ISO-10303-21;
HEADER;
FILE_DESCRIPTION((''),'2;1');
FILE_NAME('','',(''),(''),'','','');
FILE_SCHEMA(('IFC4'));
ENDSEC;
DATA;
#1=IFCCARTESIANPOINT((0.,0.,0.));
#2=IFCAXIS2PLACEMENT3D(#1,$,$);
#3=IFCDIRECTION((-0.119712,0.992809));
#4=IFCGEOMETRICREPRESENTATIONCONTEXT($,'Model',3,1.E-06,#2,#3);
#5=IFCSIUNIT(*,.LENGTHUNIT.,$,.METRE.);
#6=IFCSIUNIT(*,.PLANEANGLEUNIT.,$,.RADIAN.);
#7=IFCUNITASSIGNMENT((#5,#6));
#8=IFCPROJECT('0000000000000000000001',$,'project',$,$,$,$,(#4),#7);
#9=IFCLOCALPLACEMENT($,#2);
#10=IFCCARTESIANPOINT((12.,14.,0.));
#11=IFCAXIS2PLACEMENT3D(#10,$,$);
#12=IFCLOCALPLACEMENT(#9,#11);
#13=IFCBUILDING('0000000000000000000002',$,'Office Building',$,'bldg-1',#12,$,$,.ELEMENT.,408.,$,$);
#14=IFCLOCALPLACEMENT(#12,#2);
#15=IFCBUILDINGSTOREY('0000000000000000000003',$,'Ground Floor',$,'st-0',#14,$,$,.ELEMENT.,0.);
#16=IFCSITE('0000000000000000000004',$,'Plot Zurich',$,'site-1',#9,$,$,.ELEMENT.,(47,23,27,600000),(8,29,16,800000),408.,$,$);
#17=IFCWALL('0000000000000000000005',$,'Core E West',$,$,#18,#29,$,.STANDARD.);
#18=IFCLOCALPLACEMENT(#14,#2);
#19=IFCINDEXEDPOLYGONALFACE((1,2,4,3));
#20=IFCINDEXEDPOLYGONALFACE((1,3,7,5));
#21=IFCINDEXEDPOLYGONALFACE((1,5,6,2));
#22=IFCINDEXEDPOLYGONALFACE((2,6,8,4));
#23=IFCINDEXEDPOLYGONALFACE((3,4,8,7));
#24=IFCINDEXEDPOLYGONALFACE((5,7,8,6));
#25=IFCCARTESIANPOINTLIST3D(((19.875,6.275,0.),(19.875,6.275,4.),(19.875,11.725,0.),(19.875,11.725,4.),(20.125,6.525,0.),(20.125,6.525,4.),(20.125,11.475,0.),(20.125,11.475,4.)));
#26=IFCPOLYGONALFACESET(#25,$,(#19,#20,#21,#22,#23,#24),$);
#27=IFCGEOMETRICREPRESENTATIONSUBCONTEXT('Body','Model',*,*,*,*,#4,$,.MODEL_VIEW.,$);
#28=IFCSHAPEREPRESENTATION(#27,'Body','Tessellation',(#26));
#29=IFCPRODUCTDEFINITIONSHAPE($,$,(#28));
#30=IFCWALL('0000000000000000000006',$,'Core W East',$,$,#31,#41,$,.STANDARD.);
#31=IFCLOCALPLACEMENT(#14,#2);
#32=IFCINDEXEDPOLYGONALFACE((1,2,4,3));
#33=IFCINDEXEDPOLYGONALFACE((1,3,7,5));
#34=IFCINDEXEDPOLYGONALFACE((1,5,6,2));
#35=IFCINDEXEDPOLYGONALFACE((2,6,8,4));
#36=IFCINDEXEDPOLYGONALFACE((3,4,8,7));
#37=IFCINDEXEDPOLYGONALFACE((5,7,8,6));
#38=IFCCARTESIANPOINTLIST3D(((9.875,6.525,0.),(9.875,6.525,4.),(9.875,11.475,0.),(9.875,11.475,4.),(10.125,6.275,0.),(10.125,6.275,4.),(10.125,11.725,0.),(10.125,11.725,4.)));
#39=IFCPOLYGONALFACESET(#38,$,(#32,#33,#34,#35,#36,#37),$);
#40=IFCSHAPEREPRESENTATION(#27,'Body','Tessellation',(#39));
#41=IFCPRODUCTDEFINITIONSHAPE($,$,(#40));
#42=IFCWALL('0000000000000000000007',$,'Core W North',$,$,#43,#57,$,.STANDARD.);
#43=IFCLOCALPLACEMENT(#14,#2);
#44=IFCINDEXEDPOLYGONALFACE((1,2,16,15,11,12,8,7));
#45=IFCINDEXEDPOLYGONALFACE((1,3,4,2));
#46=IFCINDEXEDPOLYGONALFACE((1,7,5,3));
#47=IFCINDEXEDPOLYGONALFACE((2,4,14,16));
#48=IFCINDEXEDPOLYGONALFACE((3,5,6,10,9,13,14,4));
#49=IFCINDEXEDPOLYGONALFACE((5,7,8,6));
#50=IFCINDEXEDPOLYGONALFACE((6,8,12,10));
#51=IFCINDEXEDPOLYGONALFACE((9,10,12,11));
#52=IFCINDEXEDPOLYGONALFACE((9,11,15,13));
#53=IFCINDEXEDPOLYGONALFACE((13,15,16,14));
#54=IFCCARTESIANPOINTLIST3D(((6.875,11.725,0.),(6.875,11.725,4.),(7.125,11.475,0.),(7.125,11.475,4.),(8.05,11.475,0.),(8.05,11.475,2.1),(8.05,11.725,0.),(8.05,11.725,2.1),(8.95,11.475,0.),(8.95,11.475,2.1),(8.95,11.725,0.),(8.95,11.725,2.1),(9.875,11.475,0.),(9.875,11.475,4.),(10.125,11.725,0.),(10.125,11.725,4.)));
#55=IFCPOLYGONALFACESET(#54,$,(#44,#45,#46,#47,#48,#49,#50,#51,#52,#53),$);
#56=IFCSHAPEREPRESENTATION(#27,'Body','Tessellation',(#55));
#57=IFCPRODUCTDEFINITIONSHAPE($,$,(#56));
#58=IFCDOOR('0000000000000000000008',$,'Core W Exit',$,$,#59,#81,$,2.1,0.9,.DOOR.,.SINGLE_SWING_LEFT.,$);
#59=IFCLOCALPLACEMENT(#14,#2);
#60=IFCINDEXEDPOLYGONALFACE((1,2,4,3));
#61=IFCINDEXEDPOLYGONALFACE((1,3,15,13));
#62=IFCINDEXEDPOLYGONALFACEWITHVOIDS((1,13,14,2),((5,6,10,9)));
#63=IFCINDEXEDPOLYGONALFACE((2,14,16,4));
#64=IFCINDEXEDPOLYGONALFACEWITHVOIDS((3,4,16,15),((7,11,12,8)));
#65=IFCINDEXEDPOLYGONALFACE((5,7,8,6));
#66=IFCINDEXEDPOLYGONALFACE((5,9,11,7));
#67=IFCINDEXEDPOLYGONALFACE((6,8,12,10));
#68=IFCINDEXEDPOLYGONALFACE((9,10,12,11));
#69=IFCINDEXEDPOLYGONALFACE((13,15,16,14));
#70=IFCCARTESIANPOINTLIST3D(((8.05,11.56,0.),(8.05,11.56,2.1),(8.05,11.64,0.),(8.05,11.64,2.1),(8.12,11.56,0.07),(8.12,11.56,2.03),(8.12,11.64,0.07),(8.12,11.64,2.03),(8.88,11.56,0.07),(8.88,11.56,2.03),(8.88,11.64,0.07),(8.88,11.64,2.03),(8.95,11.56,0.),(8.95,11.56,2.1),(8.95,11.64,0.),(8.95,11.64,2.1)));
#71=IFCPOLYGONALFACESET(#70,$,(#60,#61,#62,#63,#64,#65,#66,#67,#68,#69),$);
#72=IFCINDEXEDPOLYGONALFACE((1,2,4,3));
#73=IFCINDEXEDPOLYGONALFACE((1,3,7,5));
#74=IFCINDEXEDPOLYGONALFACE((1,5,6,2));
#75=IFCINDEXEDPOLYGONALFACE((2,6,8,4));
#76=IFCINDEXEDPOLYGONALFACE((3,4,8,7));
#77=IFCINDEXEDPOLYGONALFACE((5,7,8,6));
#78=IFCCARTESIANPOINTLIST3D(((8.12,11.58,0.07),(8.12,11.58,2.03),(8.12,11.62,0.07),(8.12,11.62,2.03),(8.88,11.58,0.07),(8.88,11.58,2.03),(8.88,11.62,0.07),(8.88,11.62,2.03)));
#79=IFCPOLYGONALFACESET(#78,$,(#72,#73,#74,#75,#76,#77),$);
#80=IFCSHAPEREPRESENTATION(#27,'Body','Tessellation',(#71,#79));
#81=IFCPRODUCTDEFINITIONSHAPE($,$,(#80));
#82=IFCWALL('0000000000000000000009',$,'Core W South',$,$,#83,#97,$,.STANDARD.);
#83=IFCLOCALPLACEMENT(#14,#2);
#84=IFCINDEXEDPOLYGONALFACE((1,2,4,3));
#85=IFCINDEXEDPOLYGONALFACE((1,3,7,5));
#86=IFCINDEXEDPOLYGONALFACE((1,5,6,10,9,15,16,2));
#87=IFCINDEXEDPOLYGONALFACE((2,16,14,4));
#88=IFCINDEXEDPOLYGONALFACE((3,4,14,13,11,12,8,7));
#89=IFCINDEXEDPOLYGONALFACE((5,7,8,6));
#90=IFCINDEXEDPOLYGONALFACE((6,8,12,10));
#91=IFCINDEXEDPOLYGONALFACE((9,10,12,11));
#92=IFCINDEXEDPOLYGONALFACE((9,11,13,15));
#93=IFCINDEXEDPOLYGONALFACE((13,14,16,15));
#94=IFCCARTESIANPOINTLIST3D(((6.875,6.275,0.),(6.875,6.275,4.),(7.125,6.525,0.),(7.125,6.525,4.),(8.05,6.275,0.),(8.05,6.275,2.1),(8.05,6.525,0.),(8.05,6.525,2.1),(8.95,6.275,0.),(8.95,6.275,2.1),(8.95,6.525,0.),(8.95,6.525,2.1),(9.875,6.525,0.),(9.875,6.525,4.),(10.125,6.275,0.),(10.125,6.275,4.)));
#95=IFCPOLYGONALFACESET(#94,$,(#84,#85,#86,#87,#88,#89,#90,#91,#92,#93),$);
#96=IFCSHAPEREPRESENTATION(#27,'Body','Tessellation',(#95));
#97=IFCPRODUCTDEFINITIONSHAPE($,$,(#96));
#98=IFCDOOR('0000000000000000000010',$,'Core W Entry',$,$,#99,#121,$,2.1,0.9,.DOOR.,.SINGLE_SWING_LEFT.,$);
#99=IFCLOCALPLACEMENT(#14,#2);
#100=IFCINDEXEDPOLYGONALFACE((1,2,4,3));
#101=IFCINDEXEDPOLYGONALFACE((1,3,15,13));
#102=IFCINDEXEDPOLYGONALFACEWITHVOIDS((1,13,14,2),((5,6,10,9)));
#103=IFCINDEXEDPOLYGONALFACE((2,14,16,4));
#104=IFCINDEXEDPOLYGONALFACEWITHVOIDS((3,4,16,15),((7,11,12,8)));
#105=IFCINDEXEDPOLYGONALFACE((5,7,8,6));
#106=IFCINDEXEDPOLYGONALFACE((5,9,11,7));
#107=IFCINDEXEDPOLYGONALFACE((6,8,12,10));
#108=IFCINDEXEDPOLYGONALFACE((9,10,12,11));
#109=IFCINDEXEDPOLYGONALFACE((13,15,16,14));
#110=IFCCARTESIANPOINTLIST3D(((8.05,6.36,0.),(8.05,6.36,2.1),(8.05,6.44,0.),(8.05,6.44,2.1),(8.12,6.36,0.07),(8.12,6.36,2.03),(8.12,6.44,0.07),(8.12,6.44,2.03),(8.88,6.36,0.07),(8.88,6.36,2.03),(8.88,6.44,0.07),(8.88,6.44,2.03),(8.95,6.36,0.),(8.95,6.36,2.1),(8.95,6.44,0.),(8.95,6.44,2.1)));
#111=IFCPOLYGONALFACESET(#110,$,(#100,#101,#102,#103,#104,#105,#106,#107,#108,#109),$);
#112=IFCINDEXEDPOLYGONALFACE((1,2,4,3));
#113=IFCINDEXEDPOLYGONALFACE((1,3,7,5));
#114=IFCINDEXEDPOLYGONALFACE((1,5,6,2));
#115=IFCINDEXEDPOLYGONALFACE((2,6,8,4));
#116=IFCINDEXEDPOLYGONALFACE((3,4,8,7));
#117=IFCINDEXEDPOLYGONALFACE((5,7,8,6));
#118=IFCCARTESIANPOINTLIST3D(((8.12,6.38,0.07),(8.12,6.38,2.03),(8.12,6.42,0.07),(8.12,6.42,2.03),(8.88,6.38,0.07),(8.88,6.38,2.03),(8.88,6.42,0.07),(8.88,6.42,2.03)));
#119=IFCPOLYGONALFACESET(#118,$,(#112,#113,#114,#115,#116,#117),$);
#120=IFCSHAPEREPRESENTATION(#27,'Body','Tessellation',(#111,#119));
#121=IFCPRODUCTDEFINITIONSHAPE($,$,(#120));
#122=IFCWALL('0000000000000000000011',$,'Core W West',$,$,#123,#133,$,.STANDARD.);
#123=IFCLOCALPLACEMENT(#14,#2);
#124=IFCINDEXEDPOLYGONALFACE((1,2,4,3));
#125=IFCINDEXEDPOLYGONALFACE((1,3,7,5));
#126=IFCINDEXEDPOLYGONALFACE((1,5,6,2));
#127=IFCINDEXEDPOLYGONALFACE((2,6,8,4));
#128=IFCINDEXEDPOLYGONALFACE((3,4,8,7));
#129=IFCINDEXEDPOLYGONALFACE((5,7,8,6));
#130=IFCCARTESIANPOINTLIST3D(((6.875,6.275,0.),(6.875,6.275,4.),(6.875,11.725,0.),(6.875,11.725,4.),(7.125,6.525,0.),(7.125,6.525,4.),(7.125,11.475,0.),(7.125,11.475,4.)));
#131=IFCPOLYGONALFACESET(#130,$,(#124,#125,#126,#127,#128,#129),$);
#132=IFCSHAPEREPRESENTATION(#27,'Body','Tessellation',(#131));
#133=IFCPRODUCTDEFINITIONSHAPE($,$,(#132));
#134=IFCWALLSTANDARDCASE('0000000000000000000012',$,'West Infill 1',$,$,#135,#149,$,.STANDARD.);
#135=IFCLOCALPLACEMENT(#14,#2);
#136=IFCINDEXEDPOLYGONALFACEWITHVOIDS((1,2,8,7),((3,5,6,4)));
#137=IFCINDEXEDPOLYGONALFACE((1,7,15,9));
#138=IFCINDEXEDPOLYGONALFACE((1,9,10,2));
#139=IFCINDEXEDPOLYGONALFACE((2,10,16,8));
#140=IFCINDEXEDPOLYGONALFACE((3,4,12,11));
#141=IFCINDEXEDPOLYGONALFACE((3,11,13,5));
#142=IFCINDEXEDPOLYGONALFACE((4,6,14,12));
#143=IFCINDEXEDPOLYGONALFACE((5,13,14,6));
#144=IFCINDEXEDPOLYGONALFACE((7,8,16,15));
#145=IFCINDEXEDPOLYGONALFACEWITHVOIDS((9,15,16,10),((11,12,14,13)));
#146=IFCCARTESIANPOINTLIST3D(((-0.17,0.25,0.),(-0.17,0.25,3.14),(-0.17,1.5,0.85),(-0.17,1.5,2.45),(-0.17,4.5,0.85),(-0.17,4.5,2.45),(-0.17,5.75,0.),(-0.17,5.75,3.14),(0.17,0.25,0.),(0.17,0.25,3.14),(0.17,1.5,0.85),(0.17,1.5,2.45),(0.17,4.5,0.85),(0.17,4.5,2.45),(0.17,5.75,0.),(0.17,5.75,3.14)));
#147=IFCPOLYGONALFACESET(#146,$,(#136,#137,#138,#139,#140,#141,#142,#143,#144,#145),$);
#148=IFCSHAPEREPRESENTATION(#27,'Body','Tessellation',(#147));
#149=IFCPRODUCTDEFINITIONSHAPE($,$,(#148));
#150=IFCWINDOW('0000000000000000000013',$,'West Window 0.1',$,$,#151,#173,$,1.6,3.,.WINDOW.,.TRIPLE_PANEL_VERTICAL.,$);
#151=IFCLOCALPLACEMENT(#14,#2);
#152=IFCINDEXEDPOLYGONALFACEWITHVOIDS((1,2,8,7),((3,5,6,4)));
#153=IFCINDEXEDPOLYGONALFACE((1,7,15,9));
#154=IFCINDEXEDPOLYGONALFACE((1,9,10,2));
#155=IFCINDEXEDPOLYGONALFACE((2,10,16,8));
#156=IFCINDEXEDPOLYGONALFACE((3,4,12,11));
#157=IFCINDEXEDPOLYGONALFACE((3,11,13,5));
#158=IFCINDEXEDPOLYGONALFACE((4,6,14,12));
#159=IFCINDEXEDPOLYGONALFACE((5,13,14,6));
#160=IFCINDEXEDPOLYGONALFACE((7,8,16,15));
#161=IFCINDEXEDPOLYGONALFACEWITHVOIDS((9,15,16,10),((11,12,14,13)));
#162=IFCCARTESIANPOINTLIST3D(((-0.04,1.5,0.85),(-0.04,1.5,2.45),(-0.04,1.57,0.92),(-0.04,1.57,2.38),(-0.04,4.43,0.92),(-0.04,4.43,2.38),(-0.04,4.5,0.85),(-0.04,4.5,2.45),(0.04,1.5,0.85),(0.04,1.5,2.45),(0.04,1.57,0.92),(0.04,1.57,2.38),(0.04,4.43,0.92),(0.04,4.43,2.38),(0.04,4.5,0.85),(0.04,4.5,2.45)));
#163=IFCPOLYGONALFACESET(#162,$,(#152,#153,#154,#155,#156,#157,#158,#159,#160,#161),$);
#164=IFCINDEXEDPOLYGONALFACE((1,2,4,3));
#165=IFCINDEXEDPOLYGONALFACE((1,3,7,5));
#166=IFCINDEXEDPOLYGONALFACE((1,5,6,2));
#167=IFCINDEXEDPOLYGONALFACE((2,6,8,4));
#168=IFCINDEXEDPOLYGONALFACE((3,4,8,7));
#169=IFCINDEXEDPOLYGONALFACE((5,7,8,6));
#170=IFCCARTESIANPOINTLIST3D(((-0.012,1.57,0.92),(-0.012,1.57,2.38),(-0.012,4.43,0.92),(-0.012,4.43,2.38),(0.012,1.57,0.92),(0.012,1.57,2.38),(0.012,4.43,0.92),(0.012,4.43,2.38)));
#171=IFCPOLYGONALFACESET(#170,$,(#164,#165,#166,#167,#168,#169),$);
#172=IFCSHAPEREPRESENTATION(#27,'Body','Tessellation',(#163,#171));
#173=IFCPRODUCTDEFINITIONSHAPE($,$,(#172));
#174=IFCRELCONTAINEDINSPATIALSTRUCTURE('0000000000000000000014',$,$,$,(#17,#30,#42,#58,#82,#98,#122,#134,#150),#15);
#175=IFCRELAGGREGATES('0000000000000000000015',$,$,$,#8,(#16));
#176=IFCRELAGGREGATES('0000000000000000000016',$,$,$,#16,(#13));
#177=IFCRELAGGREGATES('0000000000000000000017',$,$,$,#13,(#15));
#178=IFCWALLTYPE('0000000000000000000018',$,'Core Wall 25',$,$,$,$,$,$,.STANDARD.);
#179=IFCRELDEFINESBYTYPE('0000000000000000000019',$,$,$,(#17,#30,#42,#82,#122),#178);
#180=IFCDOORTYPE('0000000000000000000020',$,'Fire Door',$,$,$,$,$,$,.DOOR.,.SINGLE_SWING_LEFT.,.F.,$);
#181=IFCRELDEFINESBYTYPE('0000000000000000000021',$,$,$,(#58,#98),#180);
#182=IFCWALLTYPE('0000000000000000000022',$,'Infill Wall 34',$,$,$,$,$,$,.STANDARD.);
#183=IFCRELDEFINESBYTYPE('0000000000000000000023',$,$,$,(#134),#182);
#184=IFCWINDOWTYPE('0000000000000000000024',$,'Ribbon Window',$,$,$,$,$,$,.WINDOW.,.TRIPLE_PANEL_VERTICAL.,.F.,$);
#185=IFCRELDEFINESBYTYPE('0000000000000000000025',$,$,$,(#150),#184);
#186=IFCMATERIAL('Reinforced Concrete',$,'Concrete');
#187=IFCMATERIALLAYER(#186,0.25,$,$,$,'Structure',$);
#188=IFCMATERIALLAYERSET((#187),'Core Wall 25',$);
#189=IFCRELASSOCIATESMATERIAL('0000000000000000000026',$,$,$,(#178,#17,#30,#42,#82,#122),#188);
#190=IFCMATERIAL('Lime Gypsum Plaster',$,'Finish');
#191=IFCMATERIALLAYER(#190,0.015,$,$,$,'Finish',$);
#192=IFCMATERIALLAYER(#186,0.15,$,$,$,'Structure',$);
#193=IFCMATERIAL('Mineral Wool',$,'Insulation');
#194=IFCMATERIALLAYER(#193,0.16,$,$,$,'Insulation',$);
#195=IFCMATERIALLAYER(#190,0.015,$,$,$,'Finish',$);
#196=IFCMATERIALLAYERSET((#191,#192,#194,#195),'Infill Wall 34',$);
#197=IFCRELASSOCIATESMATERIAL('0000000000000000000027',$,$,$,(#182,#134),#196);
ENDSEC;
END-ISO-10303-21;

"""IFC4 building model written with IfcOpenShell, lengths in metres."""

from ifc_helpers import new_model, si_unit, direction, frame, frame_2d, origin, origin_2d, place, context, subcontext, project, spatial, polyline, rectangle, outline, extrude, material, layer, layer_set, layer_usage, type_object, element, fill, save


model = new_model("IFC4")

# Units and contexts
model_context = context("Model", 3, precision=1e-06, world=origin(), true_north=direction((-0.119712, 0.992809)))
body_context = subcontext(model_context, "Body", "Model", "MODEL_VIEW")
ifc_project = project(units=[si_unit("LENGTHUNIT", "METRE"), si_unit("PLANEANGLEUNIT", "RADIAN")], contexts=[model_context])

# Site, building, storey
site_placement = place(None, origin())
site = spatial("IfcSite", under=ifc_project, at=site_placement, Name="Plot Zurich", ObjectType="site-1", CompositionType="ELEMENT", RefLatitude=(47, 23, 27, 600000), RefLongitude=(8, 29, 16, 800000), RefElevation=408.0)
building_placement = place(site_placement, frame((12.0, 14.0, 0.0)))
building = spatial("IfcBuilding", under=site, at=building_placement, Name="Office Building", ObjectType="bldg-1", CompositionType="ELEMENT", ElevationOfRefHeight=408.0)
storey_placement = place(building_placement, origin())
storey = spatial("IfcBuildingStorey", under=building, at=storey_placement, Name="Ground Floor", ObjectType="st-0", CompositionType="ELEMENT", Elevation=0.0)

# Shared definitions
ifc_material_1 = material(Name="Reinforced Concrete", Category="Concrete")

# Shared definitions
ifc_material_2 = material(Name="Mineral Wool", Category="Insulation")

# Shared definitions
ifc_layer_1 = layer(ifc_material_1, 0.25, Category="Structure")
ifc_layer_set_1 = layer_set([ifc_layer_1], Name="Core Wall 25")
wall_type_1 = type_object("IfcWallType", Name="Core Wall 25", PredefinedType="STANDARD", material=ifc_layer_set_1)

# Shared definitions
door_type = type_object("IfcDoorType", Name="Fire Door", OperationType="SINGLE_SWING_LEFT", ParameterTakesPrecedence=False, PredefinedType="DOOR")

# Walls
ifc_layer_usage_1 = layer_usage(ifc_layer_set_1, "AXIS2", "NEGATIVE", 0.125)
wall_1_placement = place(storey_placement, origin())
element("IfcWall", 1, at=wall_1_placement, inside=storey, type_object=wall_type_1, material=ifc_layer_usage_1, Name="Core E West", PredefinedType="STANDARD", context=body_context, shape_type="SweptSolid", body=[
    extrude(outline(polyline([(19.875, 11.725), (19.875, 6.275), (20.125, 6.525), (20.125, 11.475), (19.875, 11.725)])), origin(), (0.0, 0.0, 1.0), 4.0),
])
ifc_layer_usage_2 = layer_usage(ifc_layer_set_1, "AXIS2", "NEGATIVE", 0.125)
wall_2_placement = place(storey_placement, origin())
element("IfcWall", 2, at=wall_2_placement, inside=storey, type_object=wall_type_1, material=ifc_layer_usage_2, Name="Core W East", PredefinedType="STANDARD", context=body_context, shape_type="SweptSolid", body=[
    extrude(outline(polyline([(10.125, 6.275), (10.125, 11.725), (9.875, 11.475), (9.875, 6.525), (10.125, 6.275)])), origin(), (0.0, 0.0, 1.0), 4.0),
])

# Walls, openings, doors
ifc_layer_usage_3 = layer_usage(ifc_layer_set_1, "AXIS2", "NEGATIVE", 0.125)
wall_3_placement = place(storey_placement, origin())
wall_3 = element("IfcWall", 3, at=wall_3_placement, inside=storey, type_object=wall_type_1, material=ifc_layer_usage_3, Name="Core W North", PredefinedType="STANDARD", context=body_context, shape_type="SweptSolid", body=[
    extrude(outline(polyline([(10.125, 11.725), (6.875, 11.725), (7.125, 11.475), (9.875, 11.475), (10.125, 11.725)])), origin(), (0.0, 0.0, 1.0), 4.0),
])
opening_1_placement = place(wall_3_placement, frame((8.5, 11.6, 0.0), z_axis=(0.0, 0.0, 1.0), x_axis=(-1.0, 0.0, 0.0)))
opening_1 = element("IfcOpeningElement", 4, at=opening_1_placement, cuts=wall_3, PredefinedType="OPENING", context=body_context, shape_type="SweptSolid", body=[
    extrude(rectangle(XDim=0.9, YDim=0.25, at=origin_2d()), origin(), (0.0, 0.0, 1.0), 2.1),
])
door_1_placement = place(opening_1_placement, frame((0.0, 0.0, 0.0), z_axis=(0.0, -1.0, 0.0), x_axis=(1.0, 0.0, 0.0)))
door_1 = element("IfcDoor", 5, at=door_1_placement, inside=storey, type_object=door_type, Name="Core W Exit", OperationType="SINGLE_SWING_LEFT", OverallHeight=2.1, OverallWidth=0.9, PredefinedType="DOOR", context=body_context, shape_type="SweptSolid", body=[
    extrude(outline(polyline([(-0.45, 0.0), (0.45, 0.0), (0.45, 2.1), (-0.45, 2.1), (-0.45, 0.0)]), holes=[polyline([(-0.38, 0.07), (0.38, 0.07), (0.38, 2.03), (-0.38, 2.03), (-0.38, 0.07)])]), frame((0.0, 0.0, -0.04)), (0.0, 0.0, 1.0), 0.08),
    extrude(rectangle(XDim=0.76, YDim=1.96, at=frame_2d((0.0, 1.05))), frame((0.0, 0.0, -0.02)), (0.0, 0.0, 1.0), 0.04),
])
fill(opening_1, door_1)
ifc_layer_usage_4 = layer_usage(ifc_layer_set_1, "AXIS2", "NEGATIVE", 0.125)
wall_4_placement = place(storey_placement, origin())
wall_4 = element("IfcWall", 6, at=wall_4_placement, inside=storey, type_object=wall_type_1, material=ifc_layer_usage_4, Name="Core W South", PredefinedType="STANDARD", context=body_context, shape_type="SweptSolid", body=[
    extrude(outline(polyline([(6.875, 6.275), (10.125, 6.275), (9.875, 6.525), (7.125, 6.525), (6.875, 6.275)])), origin(), (0.0, 0.0, 1.0), 4.0),
])
opening_2_placement = place(wall_4_placement, frame((8.5, 6.4, 0.0), z_axis=(0.0, 0.0, 1.0), x_axis=(1.0, 0.0, 0.0)))
opening_2 = element("IfcOpeningElement", 7, at=opening_2_placement, cuts=wall_4, PredefinedType="OPENING", context=body_context, shape_type="SweptSolid", body=[
    extrude(rectangle(XDim=0.9, YDim=0.25, at=origin_2d()), origin(), (0.0, 0.0, 1.0), 2.1),
])
door_2_placement = place(opening_2_placement, frame((0.0, 0.0, 0.0), z_axis=(0.0, -1.0, 0.0), x_axis=(1.0, 0.0, 0.0)))
door_2 = element("IfcDoor", 8, at=door_2_placement, inside=storey, type_object=door_type, Name="Core W Entry", OperationType="SINGLE_SWING_LEFT", OverallHeight=2.1, OverallWidth=0.9, PredefinedType="DOOR", context=body_context, shape_type="SweptSolid", body=[
    extrude(outline(polyline([(-0.45, 0.0), (0.45, 0.0), (0.45, 2.1), (-0.45, 2.1), (-0.45, 0.0)]), holes=[polyline([(-0.38, 0.07), (0.38, 0.07), (0.38, 2.03), (-0.38, 2.03), (-0.38, 0.07)])]), frame((0.0, 0.0, -0.04)), (0.0, 0.0, 1.0), 0.08),
    extrude(rectangle(XDim=0.76, YDim=1.96, at=frame_2d((0.0, 1.05))), frame((0.0, 0.0, -0.02)), (0.0, 0.0, 1.0), 0.04),
])
fill(opening_2, door_2)

# Wall
ifc_layer_usage_5 = layer_usage(ifc_layer_set_1, "AXIS2", "NEGATIVE", 0.125)
wall_5_placement = place(storey_placement, origin())
element("IfcWall", 9, at=wall_5_placement, inside=storey, type_object=wall_type_1, material=ifc_layer_usage_5, Name="Core W West", PredefinedType="STANDARD", context=body_context, shape_type="SweptSolid", body=[
    extrude(outline(polyline([(6.875, 11.725), (6.875, 6.275), (7.125, 6.525), (7.125, 11.475), (6.875, 11.725)])), origin(), (0.0, 0.0, 1.0), 4.0),
])

# Wall, opening, window
ifc_material_3 = material(Name="Lime Gypsum Plaster", Category="Finish")
ifc_layer_2 = layer(ifc_material_3, 0.015, Category="Finish")
ifc_layer_3 = layer(ifc_material_1, 0.15, Category="Structure")
ifc_layer_4 = layer(ifc_material_2, 0.16, Category="Insulation")
ifc_layer_5 = layer(ifc_material_3, 0.015, Category="Finish")
ifc_layer_set_2 = layer_set([ifc_layer_2, ifc_layer_3, ifc_layer_4, ifc_layer_5], Name="Infill Wall 34")
ifc_layer_usage_6 = layer_usage(ifc_layer_set_2, "AXIS2", "NEGATIVE", 0.17)
wall_type_2 = type_object("IfcWallType", Name="Infill Wall 34", PredefinedType="STANDARD", material=ifc_layer_set_2)
wall_6_placement = place(storey_placement, frame((0.0, 5.75, 0.0), z_axis=(0.0, 0.0, 1.0), x_axis=(0.0, -1.0, 0.0)))
wall_6 = element("IfcWallStandardCase", 10, at=wall_6_placement, inside=storey, type_object=wall_type_2, material=ifc_layer_usage_6, Name="West Infill 1", PredefinedType="STANDARD", context=body_context, shape_type="SweptSolid", body=[
    extrude(rectangle(XDim=5.5, YDim=0.34, at=frame_2d((2.75, 0.0))), origin(), (0.0, 0.0, 1.0), 3.14),
])
opening_3_placement = place(wall_6_placement, frame((2.75, 0.0, 0.85)))
opening_3 = element("IfcOpeningElement", 11, at=opening_3_placement, cuts=wall_6, PredefinedType="OPENING", context=body_context, shape_type="SweptSolid", body=[
    extrude(rectangle(XDim=3.0, YDim=0.34, at=origin_2d()), origin(), (0.0, 0.0, 1.0), 1.6),
])
window_type = type_object("IfcWindowType", Name="Ribbon Window", ParameterTakesPrecedence=False, PartitioningType="TRIPLE_PANEL_VERTICAL", PredefinedType="WINDOW")
window_1_placement = place(opening_3_placement, frame((0.0, 0.0, 0.0), z_axis=(0.0, -1.0, 0.0), x_axis=(1.0, 0.0, 0.0)))
window_1 = element("IfcWindow", 12, at=window_1_placement, inside=storey, type_object=window_type, Name="West Window 0.1", OverallHeight=1.6, OverallWidth=3.0, PartitioningType="TRIPLE_PANEL_VERTICAL", PredefinedType="WINDOW", context=body_context, shape_type="SweptSolid", body=[
    extrude(outline(polyline([(-1.5, 0.0), (1.5, 0.0), (1.5, 1.6), (-1.5, 1.6), (-1.5, 0.0)]), holes=[polyline([(-1.43, 0.07), (1.43, 0.07), (1.43, 1.53), (-1.43, 1.53), (-1.43, 0.07)])]), frame((0.0, 0.0, -0.04)), (0.0, 0.0, 1.0), 0.08),
    extrude(rectangle(XDim=2.86, YDim=1.46, at=frame_2d((0.0, 0.8))), frame((0.0, 0.0, -0.012)), (0.0, 0.0, 1.0), 0.024),
])
fill(opening_3, window_1)

save(model, "model.ifc")
